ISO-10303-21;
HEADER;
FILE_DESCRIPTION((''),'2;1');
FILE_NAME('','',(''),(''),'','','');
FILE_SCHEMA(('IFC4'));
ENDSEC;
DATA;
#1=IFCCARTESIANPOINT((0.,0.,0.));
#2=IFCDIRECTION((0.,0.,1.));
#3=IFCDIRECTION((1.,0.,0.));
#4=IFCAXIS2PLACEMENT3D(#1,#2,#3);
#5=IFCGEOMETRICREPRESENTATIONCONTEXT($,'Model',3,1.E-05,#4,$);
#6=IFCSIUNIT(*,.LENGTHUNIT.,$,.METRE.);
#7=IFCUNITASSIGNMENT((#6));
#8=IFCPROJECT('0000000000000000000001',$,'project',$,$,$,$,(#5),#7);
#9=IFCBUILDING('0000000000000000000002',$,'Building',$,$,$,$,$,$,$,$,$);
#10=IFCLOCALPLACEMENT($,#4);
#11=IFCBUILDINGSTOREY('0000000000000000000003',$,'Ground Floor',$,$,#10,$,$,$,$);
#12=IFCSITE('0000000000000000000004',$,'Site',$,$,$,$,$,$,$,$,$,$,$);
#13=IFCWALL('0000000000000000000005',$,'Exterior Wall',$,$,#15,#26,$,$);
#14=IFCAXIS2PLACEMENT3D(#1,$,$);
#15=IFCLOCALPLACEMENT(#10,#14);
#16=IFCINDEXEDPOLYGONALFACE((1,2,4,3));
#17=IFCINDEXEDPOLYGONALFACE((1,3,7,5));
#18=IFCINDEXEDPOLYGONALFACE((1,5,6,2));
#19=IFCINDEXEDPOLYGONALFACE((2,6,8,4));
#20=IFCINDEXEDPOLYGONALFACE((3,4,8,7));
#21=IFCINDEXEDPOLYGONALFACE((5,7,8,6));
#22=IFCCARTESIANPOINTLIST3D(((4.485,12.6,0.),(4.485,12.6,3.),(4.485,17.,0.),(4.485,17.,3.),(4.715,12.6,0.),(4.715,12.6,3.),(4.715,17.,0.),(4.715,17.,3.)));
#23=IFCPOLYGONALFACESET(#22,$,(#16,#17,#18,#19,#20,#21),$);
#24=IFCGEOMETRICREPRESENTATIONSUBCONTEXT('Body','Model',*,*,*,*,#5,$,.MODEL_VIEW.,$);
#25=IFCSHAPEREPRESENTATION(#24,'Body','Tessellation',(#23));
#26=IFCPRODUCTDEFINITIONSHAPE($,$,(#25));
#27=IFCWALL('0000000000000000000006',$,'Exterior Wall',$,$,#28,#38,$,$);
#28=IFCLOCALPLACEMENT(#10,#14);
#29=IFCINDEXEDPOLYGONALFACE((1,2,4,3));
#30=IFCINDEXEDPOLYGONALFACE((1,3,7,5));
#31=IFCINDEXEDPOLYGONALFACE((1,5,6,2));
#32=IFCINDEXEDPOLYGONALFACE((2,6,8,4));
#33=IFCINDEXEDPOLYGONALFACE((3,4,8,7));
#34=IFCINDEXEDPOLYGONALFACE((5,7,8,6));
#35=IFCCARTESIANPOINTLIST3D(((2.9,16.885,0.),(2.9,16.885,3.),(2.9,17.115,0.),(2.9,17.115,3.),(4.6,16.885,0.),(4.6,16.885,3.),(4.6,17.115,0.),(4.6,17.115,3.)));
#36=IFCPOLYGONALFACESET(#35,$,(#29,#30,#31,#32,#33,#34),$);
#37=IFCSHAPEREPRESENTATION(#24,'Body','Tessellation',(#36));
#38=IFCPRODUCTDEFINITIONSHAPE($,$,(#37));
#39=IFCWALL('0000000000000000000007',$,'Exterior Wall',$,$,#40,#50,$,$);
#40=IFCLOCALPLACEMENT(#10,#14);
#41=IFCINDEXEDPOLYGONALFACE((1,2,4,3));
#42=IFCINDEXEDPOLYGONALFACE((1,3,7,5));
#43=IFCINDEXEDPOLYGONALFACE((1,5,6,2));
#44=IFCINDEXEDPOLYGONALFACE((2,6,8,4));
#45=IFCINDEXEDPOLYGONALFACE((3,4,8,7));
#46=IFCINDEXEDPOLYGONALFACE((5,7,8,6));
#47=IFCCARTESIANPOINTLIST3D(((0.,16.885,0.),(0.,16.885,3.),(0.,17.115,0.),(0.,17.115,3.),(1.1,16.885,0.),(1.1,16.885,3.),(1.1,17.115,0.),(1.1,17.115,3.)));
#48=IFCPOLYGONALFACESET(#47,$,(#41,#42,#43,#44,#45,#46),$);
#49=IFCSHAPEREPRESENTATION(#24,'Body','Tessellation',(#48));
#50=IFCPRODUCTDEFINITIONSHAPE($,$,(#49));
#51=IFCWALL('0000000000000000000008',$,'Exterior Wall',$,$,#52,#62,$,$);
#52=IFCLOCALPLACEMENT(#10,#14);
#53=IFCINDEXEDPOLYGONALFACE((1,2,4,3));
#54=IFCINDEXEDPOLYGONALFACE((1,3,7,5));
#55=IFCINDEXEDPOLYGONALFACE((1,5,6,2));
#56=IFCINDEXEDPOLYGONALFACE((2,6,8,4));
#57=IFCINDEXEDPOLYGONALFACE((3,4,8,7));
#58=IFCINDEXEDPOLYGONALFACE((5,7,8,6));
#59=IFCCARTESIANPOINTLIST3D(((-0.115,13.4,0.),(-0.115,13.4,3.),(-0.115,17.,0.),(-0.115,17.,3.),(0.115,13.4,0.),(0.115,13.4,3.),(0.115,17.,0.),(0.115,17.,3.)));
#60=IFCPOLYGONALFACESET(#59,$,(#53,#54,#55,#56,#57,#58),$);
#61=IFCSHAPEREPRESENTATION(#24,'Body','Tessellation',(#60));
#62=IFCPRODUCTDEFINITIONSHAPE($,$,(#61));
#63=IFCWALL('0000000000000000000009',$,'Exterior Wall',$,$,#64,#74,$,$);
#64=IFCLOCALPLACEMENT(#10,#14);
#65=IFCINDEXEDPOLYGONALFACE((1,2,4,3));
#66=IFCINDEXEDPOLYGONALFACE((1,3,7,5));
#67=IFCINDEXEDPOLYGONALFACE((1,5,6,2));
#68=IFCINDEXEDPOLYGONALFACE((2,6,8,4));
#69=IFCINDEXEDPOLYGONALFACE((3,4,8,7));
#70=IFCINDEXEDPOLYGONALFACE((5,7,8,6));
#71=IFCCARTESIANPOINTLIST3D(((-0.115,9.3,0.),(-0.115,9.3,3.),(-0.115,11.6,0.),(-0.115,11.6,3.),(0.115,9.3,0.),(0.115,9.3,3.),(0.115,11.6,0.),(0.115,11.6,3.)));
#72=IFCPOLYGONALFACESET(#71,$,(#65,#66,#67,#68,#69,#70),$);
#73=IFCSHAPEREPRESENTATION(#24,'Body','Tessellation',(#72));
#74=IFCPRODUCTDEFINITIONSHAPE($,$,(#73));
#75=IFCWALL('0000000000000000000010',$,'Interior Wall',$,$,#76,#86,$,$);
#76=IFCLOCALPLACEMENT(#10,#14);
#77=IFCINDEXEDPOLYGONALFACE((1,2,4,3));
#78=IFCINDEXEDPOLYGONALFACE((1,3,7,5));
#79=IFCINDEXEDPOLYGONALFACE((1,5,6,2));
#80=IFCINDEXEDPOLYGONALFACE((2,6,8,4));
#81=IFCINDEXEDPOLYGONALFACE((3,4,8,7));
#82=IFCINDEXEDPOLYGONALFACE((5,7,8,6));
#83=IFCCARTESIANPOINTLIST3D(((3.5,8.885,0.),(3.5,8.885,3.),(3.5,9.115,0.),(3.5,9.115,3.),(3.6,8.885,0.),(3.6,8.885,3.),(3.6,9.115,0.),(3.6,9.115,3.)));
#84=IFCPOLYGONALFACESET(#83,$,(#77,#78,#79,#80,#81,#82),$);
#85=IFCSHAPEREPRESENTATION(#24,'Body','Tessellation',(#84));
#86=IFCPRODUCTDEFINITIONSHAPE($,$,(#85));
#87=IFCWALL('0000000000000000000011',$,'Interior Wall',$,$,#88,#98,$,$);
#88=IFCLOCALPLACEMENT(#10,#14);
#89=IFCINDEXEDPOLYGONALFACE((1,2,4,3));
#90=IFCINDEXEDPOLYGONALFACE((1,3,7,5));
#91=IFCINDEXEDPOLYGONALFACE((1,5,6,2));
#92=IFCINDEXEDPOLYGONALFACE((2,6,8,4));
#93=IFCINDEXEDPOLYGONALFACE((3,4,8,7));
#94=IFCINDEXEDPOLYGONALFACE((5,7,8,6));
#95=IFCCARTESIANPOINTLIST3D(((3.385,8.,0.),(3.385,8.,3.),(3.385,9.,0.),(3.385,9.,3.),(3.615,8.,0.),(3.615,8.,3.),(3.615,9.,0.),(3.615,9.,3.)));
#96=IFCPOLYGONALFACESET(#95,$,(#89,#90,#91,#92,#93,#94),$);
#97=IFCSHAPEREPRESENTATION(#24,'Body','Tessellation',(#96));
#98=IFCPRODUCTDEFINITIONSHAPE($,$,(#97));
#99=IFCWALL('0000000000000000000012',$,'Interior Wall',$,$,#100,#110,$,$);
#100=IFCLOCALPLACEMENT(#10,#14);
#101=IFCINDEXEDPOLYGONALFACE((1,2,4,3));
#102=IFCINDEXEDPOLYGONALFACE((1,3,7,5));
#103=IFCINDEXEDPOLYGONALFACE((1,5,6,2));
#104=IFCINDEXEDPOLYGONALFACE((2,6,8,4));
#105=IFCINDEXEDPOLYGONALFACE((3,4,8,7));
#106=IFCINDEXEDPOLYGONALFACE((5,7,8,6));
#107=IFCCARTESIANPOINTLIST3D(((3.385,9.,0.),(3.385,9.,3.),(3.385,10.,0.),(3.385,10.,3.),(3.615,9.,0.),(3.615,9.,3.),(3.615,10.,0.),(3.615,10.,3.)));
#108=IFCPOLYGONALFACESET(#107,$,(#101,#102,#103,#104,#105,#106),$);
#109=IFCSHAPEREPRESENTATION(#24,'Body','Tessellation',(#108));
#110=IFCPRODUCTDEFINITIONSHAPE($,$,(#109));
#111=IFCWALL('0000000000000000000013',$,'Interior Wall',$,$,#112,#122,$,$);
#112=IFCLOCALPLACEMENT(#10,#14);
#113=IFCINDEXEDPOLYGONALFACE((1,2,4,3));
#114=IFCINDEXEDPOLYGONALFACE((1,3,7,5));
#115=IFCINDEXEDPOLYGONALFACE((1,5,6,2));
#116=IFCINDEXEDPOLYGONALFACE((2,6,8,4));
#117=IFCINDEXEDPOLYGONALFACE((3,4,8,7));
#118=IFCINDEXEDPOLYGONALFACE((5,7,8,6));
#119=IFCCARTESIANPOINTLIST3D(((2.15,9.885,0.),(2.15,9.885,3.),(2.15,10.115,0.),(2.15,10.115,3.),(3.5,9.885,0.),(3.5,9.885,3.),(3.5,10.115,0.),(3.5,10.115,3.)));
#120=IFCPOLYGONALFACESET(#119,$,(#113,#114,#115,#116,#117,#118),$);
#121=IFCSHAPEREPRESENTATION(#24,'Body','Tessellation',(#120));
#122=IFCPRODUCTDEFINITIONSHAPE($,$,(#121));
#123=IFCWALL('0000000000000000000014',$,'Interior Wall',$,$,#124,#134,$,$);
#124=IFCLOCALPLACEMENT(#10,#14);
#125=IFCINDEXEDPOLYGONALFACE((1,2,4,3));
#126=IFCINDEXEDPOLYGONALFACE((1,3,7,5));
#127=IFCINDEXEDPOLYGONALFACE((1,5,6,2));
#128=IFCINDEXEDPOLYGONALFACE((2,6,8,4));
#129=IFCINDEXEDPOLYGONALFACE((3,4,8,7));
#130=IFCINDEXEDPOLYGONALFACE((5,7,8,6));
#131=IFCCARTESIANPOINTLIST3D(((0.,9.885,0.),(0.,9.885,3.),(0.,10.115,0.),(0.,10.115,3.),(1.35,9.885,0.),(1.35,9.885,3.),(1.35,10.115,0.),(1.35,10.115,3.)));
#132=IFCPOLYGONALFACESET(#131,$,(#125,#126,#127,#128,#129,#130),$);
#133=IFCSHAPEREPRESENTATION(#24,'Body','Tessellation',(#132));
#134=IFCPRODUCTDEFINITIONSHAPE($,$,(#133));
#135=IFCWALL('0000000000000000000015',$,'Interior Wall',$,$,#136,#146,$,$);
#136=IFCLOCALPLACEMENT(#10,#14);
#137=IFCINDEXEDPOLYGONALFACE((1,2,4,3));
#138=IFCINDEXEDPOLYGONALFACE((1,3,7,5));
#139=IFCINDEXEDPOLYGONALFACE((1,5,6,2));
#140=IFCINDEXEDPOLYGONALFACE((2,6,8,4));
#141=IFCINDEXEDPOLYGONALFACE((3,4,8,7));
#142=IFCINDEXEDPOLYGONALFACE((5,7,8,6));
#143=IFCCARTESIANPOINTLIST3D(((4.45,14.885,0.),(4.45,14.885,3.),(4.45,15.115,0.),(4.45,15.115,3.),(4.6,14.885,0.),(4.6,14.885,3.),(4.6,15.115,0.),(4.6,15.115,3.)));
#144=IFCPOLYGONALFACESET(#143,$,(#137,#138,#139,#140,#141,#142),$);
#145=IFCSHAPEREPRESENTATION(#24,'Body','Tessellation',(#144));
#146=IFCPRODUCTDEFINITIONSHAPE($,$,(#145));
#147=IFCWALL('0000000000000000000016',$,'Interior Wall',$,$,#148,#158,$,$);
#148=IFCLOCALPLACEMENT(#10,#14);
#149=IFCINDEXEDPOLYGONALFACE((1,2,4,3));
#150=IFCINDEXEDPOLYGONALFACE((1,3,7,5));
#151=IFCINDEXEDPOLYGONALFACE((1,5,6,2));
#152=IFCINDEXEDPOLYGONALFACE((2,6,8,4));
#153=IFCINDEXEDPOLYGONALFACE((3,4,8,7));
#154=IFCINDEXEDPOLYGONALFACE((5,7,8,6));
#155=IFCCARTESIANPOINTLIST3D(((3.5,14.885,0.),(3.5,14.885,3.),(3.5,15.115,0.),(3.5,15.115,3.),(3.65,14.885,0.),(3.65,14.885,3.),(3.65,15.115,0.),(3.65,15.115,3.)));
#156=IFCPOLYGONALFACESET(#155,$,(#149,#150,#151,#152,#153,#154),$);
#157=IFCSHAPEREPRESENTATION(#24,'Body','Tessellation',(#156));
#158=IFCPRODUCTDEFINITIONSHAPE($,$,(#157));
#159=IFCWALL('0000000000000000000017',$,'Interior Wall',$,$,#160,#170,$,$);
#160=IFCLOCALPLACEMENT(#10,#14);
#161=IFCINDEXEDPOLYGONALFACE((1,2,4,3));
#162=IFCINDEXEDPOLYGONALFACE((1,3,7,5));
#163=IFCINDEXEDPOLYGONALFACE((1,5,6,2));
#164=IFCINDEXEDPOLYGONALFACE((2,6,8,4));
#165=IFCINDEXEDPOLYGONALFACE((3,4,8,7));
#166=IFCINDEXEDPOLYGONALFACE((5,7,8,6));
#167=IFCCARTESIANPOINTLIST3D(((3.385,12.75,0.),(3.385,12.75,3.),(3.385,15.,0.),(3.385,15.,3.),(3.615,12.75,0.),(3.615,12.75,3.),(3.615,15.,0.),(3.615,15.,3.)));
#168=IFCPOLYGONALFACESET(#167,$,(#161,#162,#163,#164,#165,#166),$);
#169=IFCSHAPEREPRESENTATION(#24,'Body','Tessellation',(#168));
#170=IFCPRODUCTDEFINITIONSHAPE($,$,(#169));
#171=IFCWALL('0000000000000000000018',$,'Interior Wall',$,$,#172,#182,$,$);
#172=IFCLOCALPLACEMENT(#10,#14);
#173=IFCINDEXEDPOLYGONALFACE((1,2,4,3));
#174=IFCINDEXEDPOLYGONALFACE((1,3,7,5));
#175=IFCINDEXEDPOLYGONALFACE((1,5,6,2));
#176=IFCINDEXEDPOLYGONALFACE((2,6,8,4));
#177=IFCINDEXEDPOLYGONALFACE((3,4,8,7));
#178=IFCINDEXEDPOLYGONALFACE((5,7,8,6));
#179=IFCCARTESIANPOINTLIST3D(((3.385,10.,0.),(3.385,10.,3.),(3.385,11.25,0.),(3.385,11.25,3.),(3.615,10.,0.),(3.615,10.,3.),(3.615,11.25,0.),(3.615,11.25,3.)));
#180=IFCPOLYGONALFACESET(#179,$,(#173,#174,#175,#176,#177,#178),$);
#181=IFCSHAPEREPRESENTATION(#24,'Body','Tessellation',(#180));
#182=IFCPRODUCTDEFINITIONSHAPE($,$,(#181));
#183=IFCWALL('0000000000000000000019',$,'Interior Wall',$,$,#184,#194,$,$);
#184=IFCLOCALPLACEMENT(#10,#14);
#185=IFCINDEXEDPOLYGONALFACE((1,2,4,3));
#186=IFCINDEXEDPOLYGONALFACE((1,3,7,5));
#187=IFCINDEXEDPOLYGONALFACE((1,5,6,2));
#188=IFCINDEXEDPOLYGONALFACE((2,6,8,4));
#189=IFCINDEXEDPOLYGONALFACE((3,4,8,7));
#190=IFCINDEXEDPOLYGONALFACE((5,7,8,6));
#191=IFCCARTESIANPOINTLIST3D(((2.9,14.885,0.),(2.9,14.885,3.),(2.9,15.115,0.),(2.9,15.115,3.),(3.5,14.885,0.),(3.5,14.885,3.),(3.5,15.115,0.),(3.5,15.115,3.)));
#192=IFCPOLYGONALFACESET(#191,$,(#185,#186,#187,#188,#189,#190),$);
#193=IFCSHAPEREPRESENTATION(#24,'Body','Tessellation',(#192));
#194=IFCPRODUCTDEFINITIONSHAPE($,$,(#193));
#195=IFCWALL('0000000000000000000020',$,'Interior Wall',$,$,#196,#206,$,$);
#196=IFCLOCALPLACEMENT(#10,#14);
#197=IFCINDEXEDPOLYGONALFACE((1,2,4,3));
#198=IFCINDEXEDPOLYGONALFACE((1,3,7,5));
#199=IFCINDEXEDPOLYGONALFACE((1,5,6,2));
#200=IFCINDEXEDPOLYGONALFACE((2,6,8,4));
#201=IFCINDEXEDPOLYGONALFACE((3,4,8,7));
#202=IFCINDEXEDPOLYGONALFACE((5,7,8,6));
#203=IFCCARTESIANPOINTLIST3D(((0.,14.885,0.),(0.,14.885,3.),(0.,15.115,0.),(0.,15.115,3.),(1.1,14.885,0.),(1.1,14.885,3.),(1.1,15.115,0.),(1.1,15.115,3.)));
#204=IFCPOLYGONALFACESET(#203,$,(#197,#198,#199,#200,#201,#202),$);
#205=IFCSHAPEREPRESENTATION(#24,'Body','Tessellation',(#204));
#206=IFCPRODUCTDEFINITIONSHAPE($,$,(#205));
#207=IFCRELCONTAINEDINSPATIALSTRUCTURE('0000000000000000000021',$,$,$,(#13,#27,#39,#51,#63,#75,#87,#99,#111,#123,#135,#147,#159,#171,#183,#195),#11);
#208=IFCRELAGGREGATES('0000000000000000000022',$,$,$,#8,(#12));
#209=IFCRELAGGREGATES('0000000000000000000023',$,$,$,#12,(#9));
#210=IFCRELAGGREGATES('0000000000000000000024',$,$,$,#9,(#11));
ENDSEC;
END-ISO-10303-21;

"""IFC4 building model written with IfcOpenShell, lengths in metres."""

from ifc_helpers import new_model, si_unit, frame, origin_with_axes, place, context, subcontext, project, spatial, indexed_curve, outline, extrude, element, save


model = new_model("IFC4")

# Units and contexts
model_context = context("Model", 3, precision=1e-05, world=origin_with_axes())
body_context = subcontext(model_context, "Body", "Model", "MODEL_VIEW")
ifc_project = project(units=[si_unit("LENGTHUNIT", "METRE")], contexts=[model_context])

# Site, building, storey
site = spatial("IfcSite", under=ifc_project, Name="Site")
building = spatial("IfcBuilding", under=site, Name="Building")
storey_placement = place(None, origin_with_axes())
storey = spatial("IfcBuildingStorey", under=building, at=storey_placement, Name="Ground Floor")

# Walls
wall_1_placement = place(storey_placement, frame((4.6, 12.6, 0.0), z_axis=(0.0, 0.0, 1.0), x_axis=(0.0, 1.0, 0.0)))
element("IfcWall", 1, at=wall_1_placement, inside=storey, Name="Exterior Wall", context=body_context, shape_type="SweptSolid", body=[
    extrude(outline(indexed_curve([(0.0, 0.0), (0.0, 0.23), (4.4, 0.23), (4.4, 0.0), (0.0, 0.0)], self_intersect=False)), frame((0.0, -0.115, 0.0), z_axis=(0.0, 0.0, 1.0), x_axis=(1.0, 0.0, 0.0)), (0.0, 0.0, 1.0), 3.0),
])
wall_2_placement = place(storey_placement, frame((4.6, 17.0, 0.0), z_axis=(0.0, 0.0, 1.0), x_axis=(-1.0, 0.0, 0.0)))
element("IfcWall", 2, at=wall_2_placement, inside=storey, Name="Exterior Wall", context=body_context, shape_type="SweptSolid", body=[
    extrude(outline(indexed_curve([(0.0, 0.0), (0.0, 0.23), (1.7, 0.23), (1.7, 0.0), (0.0, 0.0)], self_intersect=False)), frame((0.0, -0.115, 0.0), z_axis=(0.0, 0.0, 1.0), x_axis=(1.0, 0.0, 0.0)), (0.0, 0.0, 1.0), 3.0),
])
wall_3_placement = place(storey_placement, frame((1.1, 17.0, 0.0), z_axis=(0.0, 0.0, 1.0), x_axis=(-1.0, 0.0, 0.0)))
element("IfcWall", 3, at=wall_3_placement, inside=storey, Name="Exterior Wall", context=body_context, shape_type="SweptSolid", body=[
    extrude(outline(indexed_curve([(0.0, 0.0), (0.0, 0.23), (1.1, 0.23), (1.1, 0.0), (0.0, 0.0)], self_intersect=False)), frame((0.0, -0.115, 0.0), z_axis=(0.0, 0.0, 1.0), x_axis=(1.0, 0.0, 0.0)), (0.0, 0.0, 1.0), 3.0),
])
wall_4_placement = place(storey_placement, frame((0.0, 17.0, 0.0), z_axis=(0.0, 0.0, 1.0), x_axis=(0.0, -1.0, 0.0)))
element("IfcWall", 4, at=wall_4_placement, inside=storey, Name="Exterior Wall", context=body_context, shape_type="SweptSolid", body=[
    extrude(outline(indexed_curve([(0.0, 0.0), (0.0, 0.23), (3.6, 0.23), (3.6, 0.0), (0.0, 0.0)], self_intersect=False)), frame((0.0, -0.115, 0.0), z_axis=(0.0, 0.0, 1.0), x_axis=(1.0, 0.0, 0.0)), (0.0, 0.0, 1.0), 3.0),
])
wall_5_placement = place(storey_placement, frame((0.0, 11.6, 0.0), z_axis=(0.0, 0.0, 1.0), x_axis=(0.0, -1.0, 0.0)))
element("IfcWall", 5, at=wall_5_placement, inside=storey, Name="Exterior Wall", context=body_context, shape_type="SweptSolid", body=[
    extrude(outline(indexed_curve([(0.0, 0.0), (0.0, 0.23), (2.3, 0.23), (2.3, 0.0), (0.0, 0.0)], self_intersect=False)), frame((0.0, -0.115, 0.0), z_axis=(0.0, 0.0, 1.0), x_axis=(1.0, 0.0, 0.0)), (0.0, 0.0, 1.0), 3.0),
])
wall_6_placement = place(storey_placement, frame((3.6, 9.0, 0.0), z_axis=(0.0, 0.0, 1.0), x_axis=(-1.0, 0.0, 0.0)))
element("IfcWall", 6, at=wall_6_placement, inside=storey, Name="Interior Wall", context=body_context, shape_type="SweptSolid", body=[
    extrude(outline(indexed_curve([(0.0, 0.0), (0.0, 0.23), (0.1, 0.23), (0.1, 0.0), (0.0, 0.0)], self_intersect=False)), frame((0.0, -0.115, 0.0), z_axis=(0.0, 0.0, 1.0), x_axis=(1.0, 0.0, 0.0)), (0.0, 0.0, 1.0), 3.0),
])
for number, where, z_axis, x_axis, name in (
    (7, (3.5, 9.0, 0.0), (0.0, 0.0, 1.0), (0.0, -1.0, 0.0), "Interior Wall"),
    (8, (3.5, 9.0, 0.0), (0.0, 0.0, 1.0), (0.0, 1.0, 0.0), "Interior Wall"),
):
    element("IfcWall", number, at=place(storey_placement, frame(where, z_axis=z_axis, x_axis=x_axis)), inside=storey, Name=name, context=body_context, shape_type="SweptSolid", body=[
        extrude(outline(indexed_curve([(0.0, 0.0), (0.0, 0.23), (1.0, 0.23), (1.0, 0.0), (0.0, 0.0)], self_intersect=False)), frame((0.0, -0.115, 0.0), z_axis=(0.0, 0.0, 1.0), x_axis=(1.0, 0.0, 0.0)), (0.0, 0.0, 1.0), 3.0),
    ])
for number, where, z_axis, x_axis, name in (
    (9, (3.5, 10.0, 0.0), (0.0, 0.0, 1.0), (-1.0, 0.0, 0.0), "Interior Wall"),
    (10, (1.35, 10.0, 0.0), (0.0, 0.0, 1.0), (-1.0, 0.0, 0.0), "Interior Wall"),
):
    element("IfcWall", number, at=place(storey_placement, frame(where, z_axis=z_axis, x_axis=x_axis)), inside=storey, Name=name, context=body_context, shape_type="SweptSolid", body=[
        extrude(outline(indexed_curve([(0.0, 0.0), (0.0, 0.23), (1.35, 0.23), (1.35, 0.0), (0.0, 0.0)], self_intersect=False)), frame((0.0, -0.115, 0.0), z_axis=(0.0, 0.0, 1.0), x_axis=(1.0, 0.0, 0.0)), (0.0, 0.0, 1.0), 3.0),
    ])
wall_7_placement = place(storey_placement, frame((4.6, 15.0, 0.0), z_axis=(0.0, 0.0, 1.0), x_axis=(-1.0, 0.0, 0.0)))
element("IfcWall", 11, at=wall_7_placement, inside=storey, Name="Interior Wall", context=body_context, shape_type="SweptSolid", body=[
    extrude(outline(indexed_curve([(0.0, 0.0), (0.0, 0.23), (0.15, 0.23), (0.15, 0.0), (0.0, 0.0)], self_intersect=False)), frame((0.0, -0.115, 0.0), z_axis=(0.0, 0.0, 1.0), x_axis=(1.0, 0.0, 0.0)), (0.0, 0.0, 1.0), 3.0),
])
wall_8_placement = place(storey_placement, frame((3.65, 15.0, 0.0), z_axis=(0.0, 0.0, 1.0), x_axis=(-1.0, 0.0, 0.0)))
element("IfcWall", 12, at=wall_8_placement, inside=storey, Name="Interior Wall", context=body_context, shape_type="SweptSolid", body=[
    extrude(outline(indexed_curve([(0.0, 0.0), (0.0, 0.23), (0.15, 0.23), (0.15, 0.0), (0.0, 0.0)], self_intersect=False)), frame((0.0, -0.115, 0.0), z_axis=(0.0, 0.0, 1.0), x_axis=(1.0, 0.0, 0.0)), (0.0, 0.0, 1.0), 3.0),
])
wall_9_placement = place(storey_placement, frame((3.5, 15.0, 0.0), z_axis=(0.0, 0.0, 1.0), x_axis=(0.0, -1.0, 0.0)))
element("IfcWall", 13, at=wall_9_placement, inside=storey, Name="Interior Wall", context=body_context, shape_type="SweptSolid", body=[
    extrude(outline(indexed_curve([(0.0, 0.0), (0.0, 0.23), (2.25, 0.23), (2.25, 0.0), (0.0, 0.0)], self_intersect=False)), frame((0.0, -0.115, 0.0), z_axis=(0.0, 0.0, 1.0), x_axis=(1.0, 0.0, 0.0)), (0.0, 0.0, 1.0), 3.0),
])
wall_10_placement = place(storey_placement, frame((3.5, 11.25, 0.0), z_axis=(0.0, 0.0, 1.0), x_axis=(0.0, -1.0, 0.0)))
element("IfcWall", 14, at=wall_10_placement, inside=storey, Name="Interior Wall", context=body_context, shape_type="SweptSolid", body=[
    extrude(outline(indexed_curve([(0.0, 0.0), (0.0, 0.23), (1.25, 0.23), (1.25, 0.0), (0.0, 0.0)], self_intersect=False)), frame((0.0, -0.115, 0.0), z_axis=(0.0, 0.0, 1.0), x_axis=(1.0, 0.0, 0.0)), (0.0, 0.0, 1.0), 3.0),
])
wall_11_placement = place(storey_placement, frame((3.5, 15.0, 0.0), z_axis=(0.0, 0.0, 1.0), x_axis=(-1.0, 0.0, 0.0)))
element("IfcWall", 15, at=wall_11_placement, inside=storey, Name="Interior Wall", context=body_context, shape_type="SweptSolid", body=[
    extrude(outline(indexed_curve([(0.0, 0.0), (0.0, 0.23), (0.6, 0.23), (0.6, 0.0), (0.0, 0.0)], self_intersect=False)), frame((0.0, -0.115, 0.0), z_axis=(0.0, 0.0, 1.0), x_axis=(1.0, 0.0, 0.0)), (0.0, 0.0, 1.0), 3.0),
])
wall_12_placement = place(storey_placement, frame((1.1, 15.0, 0.0), z_axis=(0.0, 0.0, 1.0), x_axis=(-1.0, 0.0, 0.0)))
element("IfcWall", 16, at=wall_12_placement, inside=storey, Name="Interior Wall", context=body_context, shape_type="SweptSolid", body=[
    extrude(outline(indexed_curve([(0.0, 0.0), (0.0, 0.23), (1.1, 0.23), (1.1, 0.0), (0.0, 0.0)], self_intersect=False)), frame((0.0, -0.115, 0.0), z_axis=(0.0, 0.0, 1.0), x_axis=(1.0, 0.0, 0.0)), (0.0, 0.0, 1.0), 3.0),
])

save(model, "model.ifc")
